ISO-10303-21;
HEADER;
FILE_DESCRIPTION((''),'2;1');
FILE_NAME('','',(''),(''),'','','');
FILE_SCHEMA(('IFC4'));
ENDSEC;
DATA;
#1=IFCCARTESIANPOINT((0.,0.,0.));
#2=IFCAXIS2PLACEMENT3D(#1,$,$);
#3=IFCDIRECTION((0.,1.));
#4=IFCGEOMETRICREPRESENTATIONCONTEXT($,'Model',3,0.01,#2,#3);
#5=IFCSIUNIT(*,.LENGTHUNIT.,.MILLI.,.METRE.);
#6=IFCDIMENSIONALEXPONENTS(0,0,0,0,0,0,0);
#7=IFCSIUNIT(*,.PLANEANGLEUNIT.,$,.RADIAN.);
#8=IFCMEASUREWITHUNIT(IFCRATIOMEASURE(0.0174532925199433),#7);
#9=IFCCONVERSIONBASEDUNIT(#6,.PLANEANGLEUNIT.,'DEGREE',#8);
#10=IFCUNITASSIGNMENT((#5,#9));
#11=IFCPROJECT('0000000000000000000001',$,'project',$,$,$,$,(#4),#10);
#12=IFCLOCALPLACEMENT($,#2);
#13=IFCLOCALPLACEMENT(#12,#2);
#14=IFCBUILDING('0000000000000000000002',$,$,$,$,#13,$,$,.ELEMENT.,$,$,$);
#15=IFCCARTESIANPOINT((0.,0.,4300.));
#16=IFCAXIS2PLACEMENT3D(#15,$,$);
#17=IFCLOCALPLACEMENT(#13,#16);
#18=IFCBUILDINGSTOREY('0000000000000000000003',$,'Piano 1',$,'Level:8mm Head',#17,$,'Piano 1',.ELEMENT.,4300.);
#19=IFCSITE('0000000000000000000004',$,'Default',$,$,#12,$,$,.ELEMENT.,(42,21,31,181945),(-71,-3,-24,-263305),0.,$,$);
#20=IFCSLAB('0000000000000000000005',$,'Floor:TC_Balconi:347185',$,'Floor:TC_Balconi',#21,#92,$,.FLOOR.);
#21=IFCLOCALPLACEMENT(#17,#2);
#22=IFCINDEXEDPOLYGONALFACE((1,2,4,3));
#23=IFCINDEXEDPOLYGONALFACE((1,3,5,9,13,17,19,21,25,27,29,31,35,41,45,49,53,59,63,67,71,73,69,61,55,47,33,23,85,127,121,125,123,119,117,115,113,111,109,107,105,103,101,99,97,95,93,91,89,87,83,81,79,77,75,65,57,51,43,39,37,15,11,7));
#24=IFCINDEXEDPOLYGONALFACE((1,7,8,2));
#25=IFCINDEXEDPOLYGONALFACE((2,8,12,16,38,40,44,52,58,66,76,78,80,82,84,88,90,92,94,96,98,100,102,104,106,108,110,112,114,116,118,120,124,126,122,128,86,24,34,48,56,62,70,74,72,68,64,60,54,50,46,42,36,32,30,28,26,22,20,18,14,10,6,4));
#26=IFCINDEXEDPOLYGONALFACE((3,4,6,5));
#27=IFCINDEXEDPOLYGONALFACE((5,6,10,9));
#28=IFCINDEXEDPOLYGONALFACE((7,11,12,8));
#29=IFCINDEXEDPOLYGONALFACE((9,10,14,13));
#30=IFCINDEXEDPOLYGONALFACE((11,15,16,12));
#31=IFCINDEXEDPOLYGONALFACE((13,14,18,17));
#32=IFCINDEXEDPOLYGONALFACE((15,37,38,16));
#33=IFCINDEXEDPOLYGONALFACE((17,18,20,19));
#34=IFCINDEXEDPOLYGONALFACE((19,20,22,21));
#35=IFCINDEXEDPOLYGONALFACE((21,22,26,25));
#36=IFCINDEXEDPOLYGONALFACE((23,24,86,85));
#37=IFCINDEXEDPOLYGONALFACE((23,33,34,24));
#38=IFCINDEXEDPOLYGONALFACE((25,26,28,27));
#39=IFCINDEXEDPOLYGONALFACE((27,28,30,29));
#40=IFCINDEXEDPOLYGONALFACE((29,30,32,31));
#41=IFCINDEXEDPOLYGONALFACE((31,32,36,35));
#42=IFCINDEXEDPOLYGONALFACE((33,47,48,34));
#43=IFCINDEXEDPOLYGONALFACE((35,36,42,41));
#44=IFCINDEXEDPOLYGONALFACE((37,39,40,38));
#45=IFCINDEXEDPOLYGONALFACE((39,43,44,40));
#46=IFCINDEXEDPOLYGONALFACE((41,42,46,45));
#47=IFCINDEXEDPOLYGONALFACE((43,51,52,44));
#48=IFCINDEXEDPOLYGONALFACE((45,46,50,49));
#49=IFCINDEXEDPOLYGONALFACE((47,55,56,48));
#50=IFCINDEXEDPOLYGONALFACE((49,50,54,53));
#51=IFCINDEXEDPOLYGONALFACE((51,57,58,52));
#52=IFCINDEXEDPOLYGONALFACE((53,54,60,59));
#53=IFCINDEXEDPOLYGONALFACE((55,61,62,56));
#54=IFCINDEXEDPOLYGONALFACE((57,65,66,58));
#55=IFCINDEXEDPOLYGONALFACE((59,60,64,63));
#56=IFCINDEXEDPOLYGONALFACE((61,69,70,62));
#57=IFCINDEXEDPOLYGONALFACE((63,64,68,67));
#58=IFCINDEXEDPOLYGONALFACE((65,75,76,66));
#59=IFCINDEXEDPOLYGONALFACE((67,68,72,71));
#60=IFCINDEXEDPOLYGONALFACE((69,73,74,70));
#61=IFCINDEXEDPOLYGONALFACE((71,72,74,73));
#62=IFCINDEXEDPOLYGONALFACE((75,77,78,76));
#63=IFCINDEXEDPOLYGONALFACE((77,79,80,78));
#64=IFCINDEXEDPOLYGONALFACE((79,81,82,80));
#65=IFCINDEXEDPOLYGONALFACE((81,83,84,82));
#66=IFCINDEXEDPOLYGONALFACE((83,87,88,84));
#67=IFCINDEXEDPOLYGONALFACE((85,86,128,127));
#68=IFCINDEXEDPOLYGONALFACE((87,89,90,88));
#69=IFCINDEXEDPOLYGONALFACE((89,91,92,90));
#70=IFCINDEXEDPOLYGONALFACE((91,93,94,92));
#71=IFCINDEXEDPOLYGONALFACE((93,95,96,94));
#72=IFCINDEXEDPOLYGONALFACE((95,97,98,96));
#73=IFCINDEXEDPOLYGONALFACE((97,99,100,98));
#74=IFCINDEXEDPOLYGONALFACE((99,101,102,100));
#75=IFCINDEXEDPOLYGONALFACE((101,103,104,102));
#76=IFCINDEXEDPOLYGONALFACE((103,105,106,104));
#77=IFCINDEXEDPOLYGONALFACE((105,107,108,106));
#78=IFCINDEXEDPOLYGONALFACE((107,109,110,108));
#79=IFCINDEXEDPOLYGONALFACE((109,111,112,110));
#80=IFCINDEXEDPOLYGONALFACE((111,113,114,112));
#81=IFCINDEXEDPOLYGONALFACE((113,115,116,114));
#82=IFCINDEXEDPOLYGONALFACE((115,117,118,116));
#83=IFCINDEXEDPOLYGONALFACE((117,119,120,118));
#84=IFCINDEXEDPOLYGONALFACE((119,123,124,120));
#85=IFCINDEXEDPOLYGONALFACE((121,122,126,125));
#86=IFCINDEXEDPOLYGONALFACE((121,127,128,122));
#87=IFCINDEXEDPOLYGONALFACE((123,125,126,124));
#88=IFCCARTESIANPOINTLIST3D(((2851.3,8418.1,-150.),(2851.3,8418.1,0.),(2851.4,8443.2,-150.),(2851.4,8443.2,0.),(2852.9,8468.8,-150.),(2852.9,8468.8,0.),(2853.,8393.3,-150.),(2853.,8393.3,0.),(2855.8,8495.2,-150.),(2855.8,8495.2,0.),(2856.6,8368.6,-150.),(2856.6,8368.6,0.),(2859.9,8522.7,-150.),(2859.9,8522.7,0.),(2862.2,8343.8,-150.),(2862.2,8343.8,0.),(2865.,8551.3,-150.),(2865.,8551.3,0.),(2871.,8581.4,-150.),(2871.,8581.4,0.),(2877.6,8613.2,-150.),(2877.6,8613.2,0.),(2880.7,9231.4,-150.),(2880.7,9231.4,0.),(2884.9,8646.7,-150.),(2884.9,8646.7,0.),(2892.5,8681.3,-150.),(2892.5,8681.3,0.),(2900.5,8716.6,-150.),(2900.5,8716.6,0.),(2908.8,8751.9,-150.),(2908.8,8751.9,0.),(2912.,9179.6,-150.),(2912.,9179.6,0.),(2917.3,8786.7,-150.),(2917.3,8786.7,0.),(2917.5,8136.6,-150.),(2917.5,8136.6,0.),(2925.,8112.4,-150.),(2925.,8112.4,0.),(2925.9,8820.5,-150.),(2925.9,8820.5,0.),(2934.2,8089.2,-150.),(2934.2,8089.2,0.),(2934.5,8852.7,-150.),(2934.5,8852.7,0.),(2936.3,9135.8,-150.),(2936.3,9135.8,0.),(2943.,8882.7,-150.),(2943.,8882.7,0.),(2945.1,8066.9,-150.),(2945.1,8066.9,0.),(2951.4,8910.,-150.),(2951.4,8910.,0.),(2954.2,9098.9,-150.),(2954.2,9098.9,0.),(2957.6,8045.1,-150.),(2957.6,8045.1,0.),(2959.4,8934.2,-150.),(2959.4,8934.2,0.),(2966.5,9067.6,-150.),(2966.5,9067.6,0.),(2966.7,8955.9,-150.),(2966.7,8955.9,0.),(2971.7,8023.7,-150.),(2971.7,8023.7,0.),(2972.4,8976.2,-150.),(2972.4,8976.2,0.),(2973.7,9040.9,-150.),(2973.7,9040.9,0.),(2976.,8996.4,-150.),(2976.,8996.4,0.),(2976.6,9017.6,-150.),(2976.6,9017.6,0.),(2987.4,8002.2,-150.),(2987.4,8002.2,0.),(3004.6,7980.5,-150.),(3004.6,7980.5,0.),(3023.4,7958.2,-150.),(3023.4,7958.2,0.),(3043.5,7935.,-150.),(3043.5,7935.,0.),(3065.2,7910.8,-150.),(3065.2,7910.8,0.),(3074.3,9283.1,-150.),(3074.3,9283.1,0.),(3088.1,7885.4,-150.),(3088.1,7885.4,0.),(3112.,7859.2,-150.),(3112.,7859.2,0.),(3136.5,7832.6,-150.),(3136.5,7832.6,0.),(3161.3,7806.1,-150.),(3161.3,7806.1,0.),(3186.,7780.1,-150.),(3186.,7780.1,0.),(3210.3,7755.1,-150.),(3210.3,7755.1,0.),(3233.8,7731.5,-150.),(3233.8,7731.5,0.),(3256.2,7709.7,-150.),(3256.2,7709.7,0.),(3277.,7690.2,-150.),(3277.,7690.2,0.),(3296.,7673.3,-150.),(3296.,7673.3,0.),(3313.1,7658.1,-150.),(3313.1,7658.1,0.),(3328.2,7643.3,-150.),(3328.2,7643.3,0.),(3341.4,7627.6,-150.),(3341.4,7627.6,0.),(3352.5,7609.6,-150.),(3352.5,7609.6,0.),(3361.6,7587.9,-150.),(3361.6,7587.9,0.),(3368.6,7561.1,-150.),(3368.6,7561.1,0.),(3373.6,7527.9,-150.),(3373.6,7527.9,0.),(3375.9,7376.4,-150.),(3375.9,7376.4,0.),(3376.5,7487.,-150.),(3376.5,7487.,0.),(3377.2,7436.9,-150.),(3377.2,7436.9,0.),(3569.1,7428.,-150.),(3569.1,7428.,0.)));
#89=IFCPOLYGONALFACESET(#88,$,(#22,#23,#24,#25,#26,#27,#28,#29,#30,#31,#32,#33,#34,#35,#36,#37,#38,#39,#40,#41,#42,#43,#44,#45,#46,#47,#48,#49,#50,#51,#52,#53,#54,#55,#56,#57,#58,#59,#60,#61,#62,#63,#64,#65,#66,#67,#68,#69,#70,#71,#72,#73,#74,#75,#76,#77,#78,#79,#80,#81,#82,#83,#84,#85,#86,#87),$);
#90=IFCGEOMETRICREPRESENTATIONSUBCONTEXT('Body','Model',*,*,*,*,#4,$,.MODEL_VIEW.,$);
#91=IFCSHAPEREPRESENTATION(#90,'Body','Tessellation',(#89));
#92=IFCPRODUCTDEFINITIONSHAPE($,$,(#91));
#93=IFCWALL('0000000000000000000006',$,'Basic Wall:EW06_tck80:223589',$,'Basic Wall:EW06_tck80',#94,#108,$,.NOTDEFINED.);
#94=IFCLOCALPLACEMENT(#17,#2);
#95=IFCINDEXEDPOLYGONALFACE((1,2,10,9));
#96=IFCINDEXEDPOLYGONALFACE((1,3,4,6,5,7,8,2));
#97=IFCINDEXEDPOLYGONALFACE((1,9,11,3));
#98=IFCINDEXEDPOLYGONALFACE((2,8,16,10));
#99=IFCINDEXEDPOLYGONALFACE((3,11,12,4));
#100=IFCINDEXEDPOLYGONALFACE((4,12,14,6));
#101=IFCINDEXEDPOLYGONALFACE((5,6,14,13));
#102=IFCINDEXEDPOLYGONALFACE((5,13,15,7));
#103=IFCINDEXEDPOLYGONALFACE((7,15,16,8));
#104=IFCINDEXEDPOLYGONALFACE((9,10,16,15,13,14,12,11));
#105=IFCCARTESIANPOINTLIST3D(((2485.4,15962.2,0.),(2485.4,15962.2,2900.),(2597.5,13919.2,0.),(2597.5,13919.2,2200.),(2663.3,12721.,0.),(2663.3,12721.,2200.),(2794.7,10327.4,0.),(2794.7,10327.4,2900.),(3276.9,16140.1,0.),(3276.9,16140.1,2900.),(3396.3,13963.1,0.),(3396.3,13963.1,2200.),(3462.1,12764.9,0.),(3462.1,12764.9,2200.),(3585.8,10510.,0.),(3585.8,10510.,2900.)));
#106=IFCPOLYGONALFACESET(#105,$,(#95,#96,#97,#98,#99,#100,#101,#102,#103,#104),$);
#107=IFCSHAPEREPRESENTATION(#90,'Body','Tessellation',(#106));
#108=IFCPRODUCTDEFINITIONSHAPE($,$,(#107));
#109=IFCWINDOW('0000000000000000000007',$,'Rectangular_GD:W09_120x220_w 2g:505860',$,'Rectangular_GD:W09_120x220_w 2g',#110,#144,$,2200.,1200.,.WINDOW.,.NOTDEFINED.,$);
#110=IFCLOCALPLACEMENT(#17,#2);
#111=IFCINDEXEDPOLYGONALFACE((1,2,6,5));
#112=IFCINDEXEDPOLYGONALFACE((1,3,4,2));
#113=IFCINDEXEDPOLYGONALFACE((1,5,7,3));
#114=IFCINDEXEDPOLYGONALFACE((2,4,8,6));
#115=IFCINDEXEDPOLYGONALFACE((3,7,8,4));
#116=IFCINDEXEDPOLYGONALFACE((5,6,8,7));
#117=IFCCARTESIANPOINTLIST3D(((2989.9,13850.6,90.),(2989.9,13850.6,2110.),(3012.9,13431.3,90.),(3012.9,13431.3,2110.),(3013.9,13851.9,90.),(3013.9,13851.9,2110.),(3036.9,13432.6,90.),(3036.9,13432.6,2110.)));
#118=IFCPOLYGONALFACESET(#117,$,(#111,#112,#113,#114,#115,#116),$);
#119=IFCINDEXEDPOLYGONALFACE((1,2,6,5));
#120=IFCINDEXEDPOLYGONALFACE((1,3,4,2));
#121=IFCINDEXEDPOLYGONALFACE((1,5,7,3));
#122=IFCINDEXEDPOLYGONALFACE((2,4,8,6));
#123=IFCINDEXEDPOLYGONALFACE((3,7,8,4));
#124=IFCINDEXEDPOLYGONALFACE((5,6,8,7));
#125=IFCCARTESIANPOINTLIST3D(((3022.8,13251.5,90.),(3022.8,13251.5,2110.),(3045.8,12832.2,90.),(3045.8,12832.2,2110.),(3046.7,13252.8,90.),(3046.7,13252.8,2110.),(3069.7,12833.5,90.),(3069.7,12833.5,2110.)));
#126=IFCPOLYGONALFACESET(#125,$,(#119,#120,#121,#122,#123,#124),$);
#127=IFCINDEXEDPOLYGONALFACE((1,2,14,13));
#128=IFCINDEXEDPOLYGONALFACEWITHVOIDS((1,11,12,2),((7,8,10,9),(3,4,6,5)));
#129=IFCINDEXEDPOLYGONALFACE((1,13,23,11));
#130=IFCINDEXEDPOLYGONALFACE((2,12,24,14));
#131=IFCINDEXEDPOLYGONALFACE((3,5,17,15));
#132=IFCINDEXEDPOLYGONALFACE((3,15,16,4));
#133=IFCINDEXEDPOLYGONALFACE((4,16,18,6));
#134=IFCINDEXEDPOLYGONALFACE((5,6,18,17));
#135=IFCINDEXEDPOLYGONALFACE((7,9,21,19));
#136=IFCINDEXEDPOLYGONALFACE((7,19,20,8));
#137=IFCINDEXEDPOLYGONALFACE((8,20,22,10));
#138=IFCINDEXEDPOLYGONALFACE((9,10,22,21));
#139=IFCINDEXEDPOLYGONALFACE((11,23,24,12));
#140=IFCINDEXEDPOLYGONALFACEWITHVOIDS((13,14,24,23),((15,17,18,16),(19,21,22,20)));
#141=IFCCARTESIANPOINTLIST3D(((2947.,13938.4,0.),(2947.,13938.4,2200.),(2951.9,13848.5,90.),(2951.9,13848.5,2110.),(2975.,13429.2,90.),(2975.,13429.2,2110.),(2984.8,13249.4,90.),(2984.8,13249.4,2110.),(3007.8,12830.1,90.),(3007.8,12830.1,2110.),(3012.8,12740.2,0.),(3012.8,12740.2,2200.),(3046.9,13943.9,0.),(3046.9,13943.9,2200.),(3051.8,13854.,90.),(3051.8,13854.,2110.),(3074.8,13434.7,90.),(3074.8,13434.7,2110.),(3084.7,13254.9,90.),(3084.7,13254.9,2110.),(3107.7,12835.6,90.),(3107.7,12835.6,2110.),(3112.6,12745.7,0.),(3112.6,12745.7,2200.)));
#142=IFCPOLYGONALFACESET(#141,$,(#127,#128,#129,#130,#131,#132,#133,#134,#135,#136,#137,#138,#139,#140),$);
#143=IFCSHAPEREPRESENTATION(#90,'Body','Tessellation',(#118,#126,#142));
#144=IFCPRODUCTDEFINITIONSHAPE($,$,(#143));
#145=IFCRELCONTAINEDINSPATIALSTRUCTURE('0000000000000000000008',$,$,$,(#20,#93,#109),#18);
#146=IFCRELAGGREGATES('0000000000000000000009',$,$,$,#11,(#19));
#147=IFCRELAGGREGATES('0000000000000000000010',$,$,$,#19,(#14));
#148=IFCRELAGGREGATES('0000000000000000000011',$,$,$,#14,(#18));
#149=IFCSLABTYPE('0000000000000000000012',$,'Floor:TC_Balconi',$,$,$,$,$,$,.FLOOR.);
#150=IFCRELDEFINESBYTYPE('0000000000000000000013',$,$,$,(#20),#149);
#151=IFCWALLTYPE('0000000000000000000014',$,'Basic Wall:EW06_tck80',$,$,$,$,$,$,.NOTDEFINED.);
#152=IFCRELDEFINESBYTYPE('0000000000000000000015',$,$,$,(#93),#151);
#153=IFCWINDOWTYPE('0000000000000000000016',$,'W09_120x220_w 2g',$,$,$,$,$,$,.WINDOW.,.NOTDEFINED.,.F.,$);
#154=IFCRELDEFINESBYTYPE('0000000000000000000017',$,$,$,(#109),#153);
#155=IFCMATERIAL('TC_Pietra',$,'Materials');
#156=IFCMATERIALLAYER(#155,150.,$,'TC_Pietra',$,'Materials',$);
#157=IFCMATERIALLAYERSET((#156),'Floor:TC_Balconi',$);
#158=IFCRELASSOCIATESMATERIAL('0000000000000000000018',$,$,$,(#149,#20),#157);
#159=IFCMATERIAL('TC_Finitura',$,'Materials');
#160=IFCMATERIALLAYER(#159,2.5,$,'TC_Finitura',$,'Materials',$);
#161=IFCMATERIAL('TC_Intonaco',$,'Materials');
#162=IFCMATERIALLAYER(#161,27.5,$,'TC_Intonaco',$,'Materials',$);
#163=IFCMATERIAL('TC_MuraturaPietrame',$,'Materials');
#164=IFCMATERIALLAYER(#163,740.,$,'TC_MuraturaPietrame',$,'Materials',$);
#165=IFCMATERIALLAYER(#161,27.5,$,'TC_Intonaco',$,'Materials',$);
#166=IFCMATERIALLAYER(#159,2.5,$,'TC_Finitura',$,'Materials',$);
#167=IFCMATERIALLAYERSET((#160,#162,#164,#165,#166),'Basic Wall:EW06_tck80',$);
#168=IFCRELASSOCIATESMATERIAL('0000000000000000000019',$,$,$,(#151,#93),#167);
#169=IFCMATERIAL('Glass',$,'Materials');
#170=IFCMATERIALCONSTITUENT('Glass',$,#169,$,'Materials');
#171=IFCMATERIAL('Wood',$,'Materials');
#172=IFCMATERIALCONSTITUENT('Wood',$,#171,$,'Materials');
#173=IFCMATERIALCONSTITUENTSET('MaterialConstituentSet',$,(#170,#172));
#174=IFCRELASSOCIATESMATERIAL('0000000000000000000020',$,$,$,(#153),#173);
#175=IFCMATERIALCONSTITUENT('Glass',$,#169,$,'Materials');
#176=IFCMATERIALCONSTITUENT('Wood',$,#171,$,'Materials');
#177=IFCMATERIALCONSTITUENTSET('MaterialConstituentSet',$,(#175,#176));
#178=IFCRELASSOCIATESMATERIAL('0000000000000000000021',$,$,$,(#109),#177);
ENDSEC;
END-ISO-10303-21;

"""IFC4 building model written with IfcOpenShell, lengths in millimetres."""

from ifc_helpers import new_model, entity, si_unit, converted_unit, direction, frame, frame_2d, origin, origin_2d_with_axis, place, context, subcontext, project, spatial, polyline, rectangle, outline, extrude, source, transform, mapped, material, layer, layer_set, layer_usage, constituent, constituent_set, type_object, type_shapes, element, fill, save


model = new_model("IFC4")

# Units and contexts
model_context = context("Model", 3, precision=0.01, world=origin(), true_north=direction((0.0, 1.0)))
body_context = subcontext(model_context, "Body", "Model", "MODEL_VIEW")
ifc_project = project(units=[si_unit("LENGTHUNIT", "METRE", prefix="MILLI"), converted_unit("PLANEANGLEUNIT", "DEGREE", entity("IfcRatioMeasure", 0.0174532925199433), si_unit("PLANEANGLEUNIT", "RADIAN"), dimensions=[0, 0, 0, 0, 0, 0, 0])], contexts=[model_context])

# Site, building, storey
site_placement = place(None, origin())
site = spatial("IfcSite", under=ifc_project, at=site_placement, Name="Default", CompositionType="ELEMENT", RefLatitude=(42, 21, 31, 181945), RefLongitude=(-71, -3, -24, -263305), RefElevation=0.0)
building_placement = place(site_placement, origin())
building = spatial("IfcBuilding", under=site, at=building_placement, CompositionType="ELEMENT")
storey_placement = place(building_placement, frame((0.0, 0.0, 4300.0)))
storey = spatial("IfcBuildingStorey", under=building, at=storey_placement, Name="Piano 1", ObjectType="Level:8mm Head", LongName="Piano 1", CompositionType="ELEMENT", Elevation=4300.0)

# Slab
ifc_material_1 = material(Name="TC_Pietra", Category="Materials")
ifc_layer_1 = layer(ifc_material_1, 150.0, Name="TC_Pietra", Category="Materials")
ifc_layer_set_1 = layer_set([ifc_layer_1], Name="Floor:TC_Balconi")
ifc_layer_usage_1 = layer_usage(ifc_layer_set_1, "AXIS3", "POSITIVE", 0.0)
slab_type_1 = type_object("IfcSlabType", Name="Floor:TC_Balconi", PredefinedType="FLOOR", material=ifc_layer_set_1)
slab_1_placement = place(storey_placement, frame((2851.3, 7376.4, -150.0)))
element("IfcSlab", 1, at=slab_1_placement, inside=storey, type_object=slab_type_1, material=ifc_layer_usage_1, Name="Floor:TC_Balconi:347185", ObjectType="Floor:TC_Balconi", PredefinedType="FLOOR", context=body_context, shape_type="SweptSolid", body=[
    extrude(outline(polyline([(225.2, 933.5), (31.5, 985.2), (-463.2, -870.0), (-270.0, -921.5), (-271.4, -861.0), (-270.6, -810.9), (-267.7, -770.0), (-262.7, -736.8), (-255.7, -710.1), (-246.6, -688.3), (-235.5, -670.3), (-222.4, -654.6), (-207.2, -639.8), (-190.2, -624.6), (-171.1, -607.7), (-150.3, -588.2), (-127.9, -566.4), (-104.4, -542.8), (-80.2, -517.8), (-55.4, -491.8), (-30.6, -465.3), (-6.1, -438.8), (17.8, -412.5), (40.7, -387.1), (62.3, -362.9), (82.5, -339.8), (101.3, -317.5), (118.5, -295.7), (134.2, -274.3), (148.3, -252.8), (160.8, -231.0), (171.7, -208.7), (180.9, -185.6), (188.4, -161.3), (243.7, 45.9), (249.3, 70.7), (252.9, 95.4), (254.5, 120.2), (254.5, 145.2), (253.0, 170.9), (250.1, 197.3), (246.0, 224.8), (240.9, 253.4), (234.9, 283.5), (228.2, 315.3), (221.0, 348.8), (213.4, 383.4), (205.3, 418.7), (197.0, 454.0), (188.6, 488.8), (180.0, 522.6), (171.4, 554.8), (162.9, 584.8), (154.5, 612.1), (146.5, 636.3), (139.2, 658.0), (133.5, 678.3), (129.9, 698.5), (129.3, 719.7), (132.2, 743.0), (139.4, 769.7), (151.7, 801.0), (169.6, 837.9), (193.8, 881.7), (225.2, 933.5)])), frame((254.5, 921.5, 150.0), z_axis=(0.0, 0.0, -1.0), x_axis=(-1.0, 0.0, 0.0)), (0.0, 0.0, 1.0), 150.0),
])

# Wall, opening, window
ifc_material_2 = material(Name="TC_Finitura", Category="Materials")
ifc_layer_2 = layer(ifc_material_2, 2.5, Name="TC_Finitura", Category="Materials")
ifc_material_3 = material(Name="TC_Intonaco", Category="Materials")
ifc_layer_3 = layer(ifc_material_3, 27.5, Name="TC_Intonaco", Category="Materials")
ifc_material_4 = material(Name="TC_MuraturaPietrame", Category="Materials")
ifc_layer_4 = layer(ifc_material_4, 740.0, Name="TC_MuraturaPietrame", Category="Materials")
ifc_layer_5 = layer(ifc_material_3, 27.5, Name="TC_Intonaco", Category="Materials")
ifc_layer_6 = layer(ifc_material_2, 2.5, Name="TC_Finitura", Category="Materials")
ifc_layer_set_2 = layer_set([ifc_layer_2, ifc_layer_3, ifc_layer_4, ifc_layer_5, ifc_layer_6], Name="Basic Wall:EW06_tck80")
ifc_layer_usage_2 = layer_usage(ifc_layer_set_2, "AXIS2", "NEGATIVE", 400.0)
wall_type_1 = type_object("IfcWallType", Name="Basic Wall:EW06_tck80", PredefinedType="NOTDEFINED", material=ifc_layer_set_2)
wall_1_placement = place(storey_placement, frame((2877.5, 16118.2, 0.0), z_axis=(0.0, 0.0, 1.0), x_axis=(0.054795, -0.998498, 0.0)))
wall_1 = element("IfcWall", 2, at=wall_1_placement, inside=storey, type_object=wall_type_1, material=ifc_layer_usage_2, Name="Basic Wall:EW06_tck80:223589", ObjectType="Basic Wall:EW06_tck80", PredefinedType="NOTDEFINED", context=body_context, shape_type="SweptSolid", body=[
    extrude(outline(polyline([(134.3, -400.0), (5777.6, -400.0), (5777.4, -398.9), (5638.6, 400.0), (405.6, 400.0), (0.0, 400.0), (134.3, -400.0)])), origin(), (0.0, 0.0, 1.0), 2900.0),
])
opening_1_placement = place(wall_1_placement, frame((2180.4, -400.0, 0.0)))
opening_1 = element("IfcOpeningElement", 3, at=opening_1_placement, cuts=wall_1, ObjectType="Opening", PredefinedType="OPENING", context=body_context, shape_type="SweptSolid", body=[
    extrude(rectangle(XDim=2200.0, YDim=1200.0, at=frame_2d((1100.0, 600.0), x_axis=(-1.0, 0.0))), frame((0.0, 0.0, 0.0), z_axis=(0.0, 1.0, 0.0), x_axis=(0.0, 0.0, 1.0)), (0.0, 0.0, 1.0), 800.0),
])
ifc_material_5 = material(Name="Glass", Category="Materials")
ifc_constituent_1 = constituent(ifc_material_5, Name="Glass", Category="Materials")
ifc_material_6 = material(Name="Wood", Category="Materials")
ifc_constituent_2 = constituent(ifc_material_6, Name="Wood", Category="Materials")
ifc_constituent_set_1 = constituent_set(constituents=[ifc_constituent_1, ifc_constituent_2], Name="MaterialConstituentSet")
ifc_constituent_3 = constituent(ifc_material_5, Name="Glass", Category="Materials")
ifc_constituent_4 = constituent(ifc_material_6, Name="Wood", Category="Materials")
ifc_constituent_set_2 = constituent_set(constituents=[ifc_constituent_3, ifc_constituent_4], Name="MaterialConstituentSet")
window_type_1 = type_object("IfcWindowType", Name="W09_120x220_w 2g", ParameterTakesPrecedence=False, PartitioningType="NOTDEFINED", PredefinedType="WINDOW", material=ifc_constituent_set_2)
shared_shape_1 = source(origin(), body_context, "Body", "SweptSolid", [
    extrude(rectangle(XDim=24.0, YDim=420.0, at=frame_2d((0.0, 0.0), x_axis=(1.0, 0.0))), frame((300.0, 400.0, 90.0), z_axis=(0.0, 0.0, 1.0), x_axis=(0.0, 1.0, 0.0)), (0.0, 0.0, 1.0), 2020.0),
    extrude(rectangle(XDim=24.0, YDim=420.0, at=origin_2d_with_axis()), frame((900.0, 400.0, 90.0), z_axis=(0.0, 0.0, 1.0), x_axis=(0.0, 1.0, 0.0)), (0.0, 0.0, 1.0), 2020.0),
    extrude(outline(polyline([(-600.0, -1100.0), (600.0, -1100.0), (600.0, 1100.0), (-600.0, 1100.0), (-600.0, -1100.0)]), holes=[polyline([(-510.0, 1010.0), (-90.0, 1010.0), (-90.0, -1010.0), (-510.0, -1010.0), (-510.0, 1010.0)]), polyline([(90.0, -1010.0), (90.0, 1010.0), (510.0, 1010.0), (510.0, -1010.0), (90.0, -1010.0)])]), frame((600.0, 350.0, 1100.0), z_axis=(0.0, 1.0, 0.0), x_axis=(1.0, 0.0, 0.0)), (0.0, 0.0, 1.0), 100.0),
])
type_shapes(window_type_1, [shared_shape_1])
window_1_placement = place(opening_1_placement, origin())
window_1 = element("IfcWindow", 4, at=window_1_placement, inside=storey, type_object=window_type_1, material=ifc_constituent_set_1, Name="Rectangular_GD:W09_120x220_w 2g:505860", ObjectType="Rectangular_GD:W09_120x220_w 2g", OverallHeight=2200.0, OverallWidth=1200.0, PartitioningType="NOTDEFINED", PredefinedType="WINDOW", context=body_context, shape_type="MappedRepresentation", body=[
    mapped(shared_shape_1, transform((0.0, 0.0, 0.0), scale=1.0)),
])
fill(opening_1, window_1)

save(model, "model.ifc")
